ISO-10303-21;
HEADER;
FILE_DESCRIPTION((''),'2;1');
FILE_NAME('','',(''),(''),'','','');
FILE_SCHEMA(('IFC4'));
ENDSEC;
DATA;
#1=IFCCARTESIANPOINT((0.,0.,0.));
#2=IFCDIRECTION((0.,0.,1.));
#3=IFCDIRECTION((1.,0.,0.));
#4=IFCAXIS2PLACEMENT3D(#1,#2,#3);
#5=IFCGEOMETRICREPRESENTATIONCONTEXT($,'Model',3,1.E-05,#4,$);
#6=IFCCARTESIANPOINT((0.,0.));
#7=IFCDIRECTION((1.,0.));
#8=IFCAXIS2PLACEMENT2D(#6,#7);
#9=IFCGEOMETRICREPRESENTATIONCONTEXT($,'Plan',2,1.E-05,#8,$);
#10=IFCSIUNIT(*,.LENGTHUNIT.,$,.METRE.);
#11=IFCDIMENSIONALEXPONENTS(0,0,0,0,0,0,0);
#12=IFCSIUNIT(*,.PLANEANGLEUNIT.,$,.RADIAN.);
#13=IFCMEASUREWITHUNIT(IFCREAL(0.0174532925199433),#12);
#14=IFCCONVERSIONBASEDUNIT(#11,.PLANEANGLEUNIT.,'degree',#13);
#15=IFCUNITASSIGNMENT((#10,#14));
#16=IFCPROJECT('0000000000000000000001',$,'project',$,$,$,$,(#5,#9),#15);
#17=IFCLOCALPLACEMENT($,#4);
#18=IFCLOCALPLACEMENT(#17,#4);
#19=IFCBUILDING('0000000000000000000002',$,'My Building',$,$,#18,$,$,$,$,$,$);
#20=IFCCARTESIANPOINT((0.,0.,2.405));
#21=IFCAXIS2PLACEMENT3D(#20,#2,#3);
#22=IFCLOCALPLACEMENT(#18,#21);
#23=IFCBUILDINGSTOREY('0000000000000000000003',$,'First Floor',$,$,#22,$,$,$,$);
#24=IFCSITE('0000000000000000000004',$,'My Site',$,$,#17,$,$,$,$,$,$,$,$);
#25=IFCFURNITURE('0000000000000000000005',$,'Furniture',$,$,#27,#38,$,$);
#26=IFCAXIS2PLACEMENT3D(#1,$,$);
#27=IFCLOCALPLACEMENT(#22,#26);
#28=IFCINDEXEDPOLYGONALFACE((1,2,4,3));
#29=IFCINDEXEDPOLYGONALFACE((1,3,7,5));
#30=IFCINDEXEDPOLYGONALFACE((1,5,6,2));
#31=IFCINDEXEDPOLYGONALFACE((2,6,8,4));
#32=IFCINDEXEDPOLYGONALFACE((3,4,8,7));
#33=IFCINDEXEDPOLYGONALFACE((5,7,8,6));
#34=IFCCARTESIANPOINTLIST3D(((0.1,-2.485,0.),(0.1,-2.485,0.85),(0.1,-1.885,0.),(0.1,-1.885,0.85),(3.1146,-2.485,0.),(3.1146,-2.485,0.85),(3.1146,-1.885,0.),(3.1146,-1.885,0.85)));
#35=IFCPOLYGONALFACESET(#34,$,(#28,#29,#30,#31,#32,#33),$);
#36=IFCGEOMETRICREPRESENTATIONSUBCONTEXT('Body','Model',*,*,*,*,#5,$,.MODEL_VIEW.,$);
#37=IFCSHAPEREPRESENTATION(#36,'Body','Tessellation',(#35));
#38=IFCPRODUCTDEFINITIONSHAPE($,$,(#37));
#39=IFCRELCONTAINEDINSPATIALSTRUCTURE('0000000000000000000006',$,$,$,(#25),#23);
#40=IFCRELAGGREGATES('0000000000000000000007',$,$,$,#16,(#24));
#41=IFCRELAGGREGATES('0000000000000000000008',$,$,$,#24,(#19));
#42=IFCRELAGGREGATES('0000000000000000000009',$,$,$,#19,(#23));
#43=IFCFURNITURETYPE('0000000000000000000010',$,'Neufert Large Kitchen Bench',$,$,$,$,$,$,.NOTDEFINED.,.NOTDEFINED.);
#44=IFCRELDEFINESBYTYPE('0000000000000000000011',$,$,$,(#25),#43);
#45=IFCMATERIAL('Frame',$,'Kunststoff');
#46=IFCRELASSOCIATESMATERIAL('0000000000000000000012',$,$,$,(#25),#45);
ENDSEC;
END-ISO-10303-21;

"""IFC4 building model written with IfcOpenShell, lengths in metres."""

from ifc_helpers import new_model, entity, si_unit, converted_unit, frame, origin_with_axes, origin_2d_with_axis, place, context, subcontext, project, spatial, polyline, outline, extrude, source, transform, mapped, material, type_object, type_shapes, element, save


model = new_model("IFC4")

# Units and contexts
model_context = context("Model", 3, precision=1e-05, world=origin_with_axes())
plan_context = context("Plan", 2, precision=1e-05, world=origin_2d_with_axis())
body_context = subcontext(model_context, "Body", "Model", "MODEL_VIEW")
ifc_project = project(units=[si_unit("LENGTHUNIT", "METRE"), converted_unit("PLANEANGLEUNIT", "degree", entity("IfcReal", 0.0174532925199433), si_unit("PLANEANGLEUNIT", "RADIAN"), dimensions=[0, 0, 0, 0, 0, 0, 0])], contexts=[model_context, plan_context])

# Site, building, storey
site_placement = place(None, origin_with_axes())
site = spatial("IfcSite", under=ifc_project, at=site_placement, Name="My Site")
building_placement = place(site_placement, origin_with_axes())
building = spatial("IfcBuilding", under=site, at=building_placement, Name="My Building")
storey_placement = place(building_placement, frame((0.0, 0.0, 2.405), z_axis=(0.0, 0.0, 1.0), x_axis=(1.0, 0.0, 0.0)))
storey = spatial("IfcBuildingStorey", under=building, at=storey_placement, Name="First Floor")

# Furniture
ifc_material_1 = material(Name="Frame", Category="Kunststoff")
furniture_type_1 = type_object("IfcFurnitureType", Name="Neufert Large Kitchen Bench", AssemblyPlace="NOTDEFINED", PredefinedType="NOTDEFINED")
shared_shape_1 = source(origin_with_axes(), body_context, "Body", "SweptSolid", [
    extrude(outline(polyline([(-1.5073, -0.3), (1.5073, -0.3), (1.5073, 0.3), (-1.5073, 0.3), (-1.5073, -0.3)])), frame((1.5073, 0.3, 0.0), z_axis=(0.0, 0.0, -1.0), x_axis=(-1.0, 0.0, 0.0)), (0.0, 0.0, -1.0), 0.85),
])
type_shapes(furniture_type_1, [shared_shape_1])
furniture_1_placement = place(storey_placement, frame((0.1, -2.485, 0.0), z_axis=(0.0, 0.0, 1.0), x_axis=(1.0, 0.0, 0.0)))
element("IfcFurniture", 1, at=furniture_1_placement, inside=storey, type_object=furniture_type_1, material=ifc_material_1, Name="Furniture", context=body_context, shape_type="MappedRepresentation", body=[
    mapped(shared_shape_1, transform((0.0, 0.0, 0.0), x_axis=(1.0, 0.0, 0.0), y_axis=(0.0, 1.0, 0.0), z_axis=(0.0, 0.0, 1.0), scale=1.0)),
])

save(model, "model.ifc")
